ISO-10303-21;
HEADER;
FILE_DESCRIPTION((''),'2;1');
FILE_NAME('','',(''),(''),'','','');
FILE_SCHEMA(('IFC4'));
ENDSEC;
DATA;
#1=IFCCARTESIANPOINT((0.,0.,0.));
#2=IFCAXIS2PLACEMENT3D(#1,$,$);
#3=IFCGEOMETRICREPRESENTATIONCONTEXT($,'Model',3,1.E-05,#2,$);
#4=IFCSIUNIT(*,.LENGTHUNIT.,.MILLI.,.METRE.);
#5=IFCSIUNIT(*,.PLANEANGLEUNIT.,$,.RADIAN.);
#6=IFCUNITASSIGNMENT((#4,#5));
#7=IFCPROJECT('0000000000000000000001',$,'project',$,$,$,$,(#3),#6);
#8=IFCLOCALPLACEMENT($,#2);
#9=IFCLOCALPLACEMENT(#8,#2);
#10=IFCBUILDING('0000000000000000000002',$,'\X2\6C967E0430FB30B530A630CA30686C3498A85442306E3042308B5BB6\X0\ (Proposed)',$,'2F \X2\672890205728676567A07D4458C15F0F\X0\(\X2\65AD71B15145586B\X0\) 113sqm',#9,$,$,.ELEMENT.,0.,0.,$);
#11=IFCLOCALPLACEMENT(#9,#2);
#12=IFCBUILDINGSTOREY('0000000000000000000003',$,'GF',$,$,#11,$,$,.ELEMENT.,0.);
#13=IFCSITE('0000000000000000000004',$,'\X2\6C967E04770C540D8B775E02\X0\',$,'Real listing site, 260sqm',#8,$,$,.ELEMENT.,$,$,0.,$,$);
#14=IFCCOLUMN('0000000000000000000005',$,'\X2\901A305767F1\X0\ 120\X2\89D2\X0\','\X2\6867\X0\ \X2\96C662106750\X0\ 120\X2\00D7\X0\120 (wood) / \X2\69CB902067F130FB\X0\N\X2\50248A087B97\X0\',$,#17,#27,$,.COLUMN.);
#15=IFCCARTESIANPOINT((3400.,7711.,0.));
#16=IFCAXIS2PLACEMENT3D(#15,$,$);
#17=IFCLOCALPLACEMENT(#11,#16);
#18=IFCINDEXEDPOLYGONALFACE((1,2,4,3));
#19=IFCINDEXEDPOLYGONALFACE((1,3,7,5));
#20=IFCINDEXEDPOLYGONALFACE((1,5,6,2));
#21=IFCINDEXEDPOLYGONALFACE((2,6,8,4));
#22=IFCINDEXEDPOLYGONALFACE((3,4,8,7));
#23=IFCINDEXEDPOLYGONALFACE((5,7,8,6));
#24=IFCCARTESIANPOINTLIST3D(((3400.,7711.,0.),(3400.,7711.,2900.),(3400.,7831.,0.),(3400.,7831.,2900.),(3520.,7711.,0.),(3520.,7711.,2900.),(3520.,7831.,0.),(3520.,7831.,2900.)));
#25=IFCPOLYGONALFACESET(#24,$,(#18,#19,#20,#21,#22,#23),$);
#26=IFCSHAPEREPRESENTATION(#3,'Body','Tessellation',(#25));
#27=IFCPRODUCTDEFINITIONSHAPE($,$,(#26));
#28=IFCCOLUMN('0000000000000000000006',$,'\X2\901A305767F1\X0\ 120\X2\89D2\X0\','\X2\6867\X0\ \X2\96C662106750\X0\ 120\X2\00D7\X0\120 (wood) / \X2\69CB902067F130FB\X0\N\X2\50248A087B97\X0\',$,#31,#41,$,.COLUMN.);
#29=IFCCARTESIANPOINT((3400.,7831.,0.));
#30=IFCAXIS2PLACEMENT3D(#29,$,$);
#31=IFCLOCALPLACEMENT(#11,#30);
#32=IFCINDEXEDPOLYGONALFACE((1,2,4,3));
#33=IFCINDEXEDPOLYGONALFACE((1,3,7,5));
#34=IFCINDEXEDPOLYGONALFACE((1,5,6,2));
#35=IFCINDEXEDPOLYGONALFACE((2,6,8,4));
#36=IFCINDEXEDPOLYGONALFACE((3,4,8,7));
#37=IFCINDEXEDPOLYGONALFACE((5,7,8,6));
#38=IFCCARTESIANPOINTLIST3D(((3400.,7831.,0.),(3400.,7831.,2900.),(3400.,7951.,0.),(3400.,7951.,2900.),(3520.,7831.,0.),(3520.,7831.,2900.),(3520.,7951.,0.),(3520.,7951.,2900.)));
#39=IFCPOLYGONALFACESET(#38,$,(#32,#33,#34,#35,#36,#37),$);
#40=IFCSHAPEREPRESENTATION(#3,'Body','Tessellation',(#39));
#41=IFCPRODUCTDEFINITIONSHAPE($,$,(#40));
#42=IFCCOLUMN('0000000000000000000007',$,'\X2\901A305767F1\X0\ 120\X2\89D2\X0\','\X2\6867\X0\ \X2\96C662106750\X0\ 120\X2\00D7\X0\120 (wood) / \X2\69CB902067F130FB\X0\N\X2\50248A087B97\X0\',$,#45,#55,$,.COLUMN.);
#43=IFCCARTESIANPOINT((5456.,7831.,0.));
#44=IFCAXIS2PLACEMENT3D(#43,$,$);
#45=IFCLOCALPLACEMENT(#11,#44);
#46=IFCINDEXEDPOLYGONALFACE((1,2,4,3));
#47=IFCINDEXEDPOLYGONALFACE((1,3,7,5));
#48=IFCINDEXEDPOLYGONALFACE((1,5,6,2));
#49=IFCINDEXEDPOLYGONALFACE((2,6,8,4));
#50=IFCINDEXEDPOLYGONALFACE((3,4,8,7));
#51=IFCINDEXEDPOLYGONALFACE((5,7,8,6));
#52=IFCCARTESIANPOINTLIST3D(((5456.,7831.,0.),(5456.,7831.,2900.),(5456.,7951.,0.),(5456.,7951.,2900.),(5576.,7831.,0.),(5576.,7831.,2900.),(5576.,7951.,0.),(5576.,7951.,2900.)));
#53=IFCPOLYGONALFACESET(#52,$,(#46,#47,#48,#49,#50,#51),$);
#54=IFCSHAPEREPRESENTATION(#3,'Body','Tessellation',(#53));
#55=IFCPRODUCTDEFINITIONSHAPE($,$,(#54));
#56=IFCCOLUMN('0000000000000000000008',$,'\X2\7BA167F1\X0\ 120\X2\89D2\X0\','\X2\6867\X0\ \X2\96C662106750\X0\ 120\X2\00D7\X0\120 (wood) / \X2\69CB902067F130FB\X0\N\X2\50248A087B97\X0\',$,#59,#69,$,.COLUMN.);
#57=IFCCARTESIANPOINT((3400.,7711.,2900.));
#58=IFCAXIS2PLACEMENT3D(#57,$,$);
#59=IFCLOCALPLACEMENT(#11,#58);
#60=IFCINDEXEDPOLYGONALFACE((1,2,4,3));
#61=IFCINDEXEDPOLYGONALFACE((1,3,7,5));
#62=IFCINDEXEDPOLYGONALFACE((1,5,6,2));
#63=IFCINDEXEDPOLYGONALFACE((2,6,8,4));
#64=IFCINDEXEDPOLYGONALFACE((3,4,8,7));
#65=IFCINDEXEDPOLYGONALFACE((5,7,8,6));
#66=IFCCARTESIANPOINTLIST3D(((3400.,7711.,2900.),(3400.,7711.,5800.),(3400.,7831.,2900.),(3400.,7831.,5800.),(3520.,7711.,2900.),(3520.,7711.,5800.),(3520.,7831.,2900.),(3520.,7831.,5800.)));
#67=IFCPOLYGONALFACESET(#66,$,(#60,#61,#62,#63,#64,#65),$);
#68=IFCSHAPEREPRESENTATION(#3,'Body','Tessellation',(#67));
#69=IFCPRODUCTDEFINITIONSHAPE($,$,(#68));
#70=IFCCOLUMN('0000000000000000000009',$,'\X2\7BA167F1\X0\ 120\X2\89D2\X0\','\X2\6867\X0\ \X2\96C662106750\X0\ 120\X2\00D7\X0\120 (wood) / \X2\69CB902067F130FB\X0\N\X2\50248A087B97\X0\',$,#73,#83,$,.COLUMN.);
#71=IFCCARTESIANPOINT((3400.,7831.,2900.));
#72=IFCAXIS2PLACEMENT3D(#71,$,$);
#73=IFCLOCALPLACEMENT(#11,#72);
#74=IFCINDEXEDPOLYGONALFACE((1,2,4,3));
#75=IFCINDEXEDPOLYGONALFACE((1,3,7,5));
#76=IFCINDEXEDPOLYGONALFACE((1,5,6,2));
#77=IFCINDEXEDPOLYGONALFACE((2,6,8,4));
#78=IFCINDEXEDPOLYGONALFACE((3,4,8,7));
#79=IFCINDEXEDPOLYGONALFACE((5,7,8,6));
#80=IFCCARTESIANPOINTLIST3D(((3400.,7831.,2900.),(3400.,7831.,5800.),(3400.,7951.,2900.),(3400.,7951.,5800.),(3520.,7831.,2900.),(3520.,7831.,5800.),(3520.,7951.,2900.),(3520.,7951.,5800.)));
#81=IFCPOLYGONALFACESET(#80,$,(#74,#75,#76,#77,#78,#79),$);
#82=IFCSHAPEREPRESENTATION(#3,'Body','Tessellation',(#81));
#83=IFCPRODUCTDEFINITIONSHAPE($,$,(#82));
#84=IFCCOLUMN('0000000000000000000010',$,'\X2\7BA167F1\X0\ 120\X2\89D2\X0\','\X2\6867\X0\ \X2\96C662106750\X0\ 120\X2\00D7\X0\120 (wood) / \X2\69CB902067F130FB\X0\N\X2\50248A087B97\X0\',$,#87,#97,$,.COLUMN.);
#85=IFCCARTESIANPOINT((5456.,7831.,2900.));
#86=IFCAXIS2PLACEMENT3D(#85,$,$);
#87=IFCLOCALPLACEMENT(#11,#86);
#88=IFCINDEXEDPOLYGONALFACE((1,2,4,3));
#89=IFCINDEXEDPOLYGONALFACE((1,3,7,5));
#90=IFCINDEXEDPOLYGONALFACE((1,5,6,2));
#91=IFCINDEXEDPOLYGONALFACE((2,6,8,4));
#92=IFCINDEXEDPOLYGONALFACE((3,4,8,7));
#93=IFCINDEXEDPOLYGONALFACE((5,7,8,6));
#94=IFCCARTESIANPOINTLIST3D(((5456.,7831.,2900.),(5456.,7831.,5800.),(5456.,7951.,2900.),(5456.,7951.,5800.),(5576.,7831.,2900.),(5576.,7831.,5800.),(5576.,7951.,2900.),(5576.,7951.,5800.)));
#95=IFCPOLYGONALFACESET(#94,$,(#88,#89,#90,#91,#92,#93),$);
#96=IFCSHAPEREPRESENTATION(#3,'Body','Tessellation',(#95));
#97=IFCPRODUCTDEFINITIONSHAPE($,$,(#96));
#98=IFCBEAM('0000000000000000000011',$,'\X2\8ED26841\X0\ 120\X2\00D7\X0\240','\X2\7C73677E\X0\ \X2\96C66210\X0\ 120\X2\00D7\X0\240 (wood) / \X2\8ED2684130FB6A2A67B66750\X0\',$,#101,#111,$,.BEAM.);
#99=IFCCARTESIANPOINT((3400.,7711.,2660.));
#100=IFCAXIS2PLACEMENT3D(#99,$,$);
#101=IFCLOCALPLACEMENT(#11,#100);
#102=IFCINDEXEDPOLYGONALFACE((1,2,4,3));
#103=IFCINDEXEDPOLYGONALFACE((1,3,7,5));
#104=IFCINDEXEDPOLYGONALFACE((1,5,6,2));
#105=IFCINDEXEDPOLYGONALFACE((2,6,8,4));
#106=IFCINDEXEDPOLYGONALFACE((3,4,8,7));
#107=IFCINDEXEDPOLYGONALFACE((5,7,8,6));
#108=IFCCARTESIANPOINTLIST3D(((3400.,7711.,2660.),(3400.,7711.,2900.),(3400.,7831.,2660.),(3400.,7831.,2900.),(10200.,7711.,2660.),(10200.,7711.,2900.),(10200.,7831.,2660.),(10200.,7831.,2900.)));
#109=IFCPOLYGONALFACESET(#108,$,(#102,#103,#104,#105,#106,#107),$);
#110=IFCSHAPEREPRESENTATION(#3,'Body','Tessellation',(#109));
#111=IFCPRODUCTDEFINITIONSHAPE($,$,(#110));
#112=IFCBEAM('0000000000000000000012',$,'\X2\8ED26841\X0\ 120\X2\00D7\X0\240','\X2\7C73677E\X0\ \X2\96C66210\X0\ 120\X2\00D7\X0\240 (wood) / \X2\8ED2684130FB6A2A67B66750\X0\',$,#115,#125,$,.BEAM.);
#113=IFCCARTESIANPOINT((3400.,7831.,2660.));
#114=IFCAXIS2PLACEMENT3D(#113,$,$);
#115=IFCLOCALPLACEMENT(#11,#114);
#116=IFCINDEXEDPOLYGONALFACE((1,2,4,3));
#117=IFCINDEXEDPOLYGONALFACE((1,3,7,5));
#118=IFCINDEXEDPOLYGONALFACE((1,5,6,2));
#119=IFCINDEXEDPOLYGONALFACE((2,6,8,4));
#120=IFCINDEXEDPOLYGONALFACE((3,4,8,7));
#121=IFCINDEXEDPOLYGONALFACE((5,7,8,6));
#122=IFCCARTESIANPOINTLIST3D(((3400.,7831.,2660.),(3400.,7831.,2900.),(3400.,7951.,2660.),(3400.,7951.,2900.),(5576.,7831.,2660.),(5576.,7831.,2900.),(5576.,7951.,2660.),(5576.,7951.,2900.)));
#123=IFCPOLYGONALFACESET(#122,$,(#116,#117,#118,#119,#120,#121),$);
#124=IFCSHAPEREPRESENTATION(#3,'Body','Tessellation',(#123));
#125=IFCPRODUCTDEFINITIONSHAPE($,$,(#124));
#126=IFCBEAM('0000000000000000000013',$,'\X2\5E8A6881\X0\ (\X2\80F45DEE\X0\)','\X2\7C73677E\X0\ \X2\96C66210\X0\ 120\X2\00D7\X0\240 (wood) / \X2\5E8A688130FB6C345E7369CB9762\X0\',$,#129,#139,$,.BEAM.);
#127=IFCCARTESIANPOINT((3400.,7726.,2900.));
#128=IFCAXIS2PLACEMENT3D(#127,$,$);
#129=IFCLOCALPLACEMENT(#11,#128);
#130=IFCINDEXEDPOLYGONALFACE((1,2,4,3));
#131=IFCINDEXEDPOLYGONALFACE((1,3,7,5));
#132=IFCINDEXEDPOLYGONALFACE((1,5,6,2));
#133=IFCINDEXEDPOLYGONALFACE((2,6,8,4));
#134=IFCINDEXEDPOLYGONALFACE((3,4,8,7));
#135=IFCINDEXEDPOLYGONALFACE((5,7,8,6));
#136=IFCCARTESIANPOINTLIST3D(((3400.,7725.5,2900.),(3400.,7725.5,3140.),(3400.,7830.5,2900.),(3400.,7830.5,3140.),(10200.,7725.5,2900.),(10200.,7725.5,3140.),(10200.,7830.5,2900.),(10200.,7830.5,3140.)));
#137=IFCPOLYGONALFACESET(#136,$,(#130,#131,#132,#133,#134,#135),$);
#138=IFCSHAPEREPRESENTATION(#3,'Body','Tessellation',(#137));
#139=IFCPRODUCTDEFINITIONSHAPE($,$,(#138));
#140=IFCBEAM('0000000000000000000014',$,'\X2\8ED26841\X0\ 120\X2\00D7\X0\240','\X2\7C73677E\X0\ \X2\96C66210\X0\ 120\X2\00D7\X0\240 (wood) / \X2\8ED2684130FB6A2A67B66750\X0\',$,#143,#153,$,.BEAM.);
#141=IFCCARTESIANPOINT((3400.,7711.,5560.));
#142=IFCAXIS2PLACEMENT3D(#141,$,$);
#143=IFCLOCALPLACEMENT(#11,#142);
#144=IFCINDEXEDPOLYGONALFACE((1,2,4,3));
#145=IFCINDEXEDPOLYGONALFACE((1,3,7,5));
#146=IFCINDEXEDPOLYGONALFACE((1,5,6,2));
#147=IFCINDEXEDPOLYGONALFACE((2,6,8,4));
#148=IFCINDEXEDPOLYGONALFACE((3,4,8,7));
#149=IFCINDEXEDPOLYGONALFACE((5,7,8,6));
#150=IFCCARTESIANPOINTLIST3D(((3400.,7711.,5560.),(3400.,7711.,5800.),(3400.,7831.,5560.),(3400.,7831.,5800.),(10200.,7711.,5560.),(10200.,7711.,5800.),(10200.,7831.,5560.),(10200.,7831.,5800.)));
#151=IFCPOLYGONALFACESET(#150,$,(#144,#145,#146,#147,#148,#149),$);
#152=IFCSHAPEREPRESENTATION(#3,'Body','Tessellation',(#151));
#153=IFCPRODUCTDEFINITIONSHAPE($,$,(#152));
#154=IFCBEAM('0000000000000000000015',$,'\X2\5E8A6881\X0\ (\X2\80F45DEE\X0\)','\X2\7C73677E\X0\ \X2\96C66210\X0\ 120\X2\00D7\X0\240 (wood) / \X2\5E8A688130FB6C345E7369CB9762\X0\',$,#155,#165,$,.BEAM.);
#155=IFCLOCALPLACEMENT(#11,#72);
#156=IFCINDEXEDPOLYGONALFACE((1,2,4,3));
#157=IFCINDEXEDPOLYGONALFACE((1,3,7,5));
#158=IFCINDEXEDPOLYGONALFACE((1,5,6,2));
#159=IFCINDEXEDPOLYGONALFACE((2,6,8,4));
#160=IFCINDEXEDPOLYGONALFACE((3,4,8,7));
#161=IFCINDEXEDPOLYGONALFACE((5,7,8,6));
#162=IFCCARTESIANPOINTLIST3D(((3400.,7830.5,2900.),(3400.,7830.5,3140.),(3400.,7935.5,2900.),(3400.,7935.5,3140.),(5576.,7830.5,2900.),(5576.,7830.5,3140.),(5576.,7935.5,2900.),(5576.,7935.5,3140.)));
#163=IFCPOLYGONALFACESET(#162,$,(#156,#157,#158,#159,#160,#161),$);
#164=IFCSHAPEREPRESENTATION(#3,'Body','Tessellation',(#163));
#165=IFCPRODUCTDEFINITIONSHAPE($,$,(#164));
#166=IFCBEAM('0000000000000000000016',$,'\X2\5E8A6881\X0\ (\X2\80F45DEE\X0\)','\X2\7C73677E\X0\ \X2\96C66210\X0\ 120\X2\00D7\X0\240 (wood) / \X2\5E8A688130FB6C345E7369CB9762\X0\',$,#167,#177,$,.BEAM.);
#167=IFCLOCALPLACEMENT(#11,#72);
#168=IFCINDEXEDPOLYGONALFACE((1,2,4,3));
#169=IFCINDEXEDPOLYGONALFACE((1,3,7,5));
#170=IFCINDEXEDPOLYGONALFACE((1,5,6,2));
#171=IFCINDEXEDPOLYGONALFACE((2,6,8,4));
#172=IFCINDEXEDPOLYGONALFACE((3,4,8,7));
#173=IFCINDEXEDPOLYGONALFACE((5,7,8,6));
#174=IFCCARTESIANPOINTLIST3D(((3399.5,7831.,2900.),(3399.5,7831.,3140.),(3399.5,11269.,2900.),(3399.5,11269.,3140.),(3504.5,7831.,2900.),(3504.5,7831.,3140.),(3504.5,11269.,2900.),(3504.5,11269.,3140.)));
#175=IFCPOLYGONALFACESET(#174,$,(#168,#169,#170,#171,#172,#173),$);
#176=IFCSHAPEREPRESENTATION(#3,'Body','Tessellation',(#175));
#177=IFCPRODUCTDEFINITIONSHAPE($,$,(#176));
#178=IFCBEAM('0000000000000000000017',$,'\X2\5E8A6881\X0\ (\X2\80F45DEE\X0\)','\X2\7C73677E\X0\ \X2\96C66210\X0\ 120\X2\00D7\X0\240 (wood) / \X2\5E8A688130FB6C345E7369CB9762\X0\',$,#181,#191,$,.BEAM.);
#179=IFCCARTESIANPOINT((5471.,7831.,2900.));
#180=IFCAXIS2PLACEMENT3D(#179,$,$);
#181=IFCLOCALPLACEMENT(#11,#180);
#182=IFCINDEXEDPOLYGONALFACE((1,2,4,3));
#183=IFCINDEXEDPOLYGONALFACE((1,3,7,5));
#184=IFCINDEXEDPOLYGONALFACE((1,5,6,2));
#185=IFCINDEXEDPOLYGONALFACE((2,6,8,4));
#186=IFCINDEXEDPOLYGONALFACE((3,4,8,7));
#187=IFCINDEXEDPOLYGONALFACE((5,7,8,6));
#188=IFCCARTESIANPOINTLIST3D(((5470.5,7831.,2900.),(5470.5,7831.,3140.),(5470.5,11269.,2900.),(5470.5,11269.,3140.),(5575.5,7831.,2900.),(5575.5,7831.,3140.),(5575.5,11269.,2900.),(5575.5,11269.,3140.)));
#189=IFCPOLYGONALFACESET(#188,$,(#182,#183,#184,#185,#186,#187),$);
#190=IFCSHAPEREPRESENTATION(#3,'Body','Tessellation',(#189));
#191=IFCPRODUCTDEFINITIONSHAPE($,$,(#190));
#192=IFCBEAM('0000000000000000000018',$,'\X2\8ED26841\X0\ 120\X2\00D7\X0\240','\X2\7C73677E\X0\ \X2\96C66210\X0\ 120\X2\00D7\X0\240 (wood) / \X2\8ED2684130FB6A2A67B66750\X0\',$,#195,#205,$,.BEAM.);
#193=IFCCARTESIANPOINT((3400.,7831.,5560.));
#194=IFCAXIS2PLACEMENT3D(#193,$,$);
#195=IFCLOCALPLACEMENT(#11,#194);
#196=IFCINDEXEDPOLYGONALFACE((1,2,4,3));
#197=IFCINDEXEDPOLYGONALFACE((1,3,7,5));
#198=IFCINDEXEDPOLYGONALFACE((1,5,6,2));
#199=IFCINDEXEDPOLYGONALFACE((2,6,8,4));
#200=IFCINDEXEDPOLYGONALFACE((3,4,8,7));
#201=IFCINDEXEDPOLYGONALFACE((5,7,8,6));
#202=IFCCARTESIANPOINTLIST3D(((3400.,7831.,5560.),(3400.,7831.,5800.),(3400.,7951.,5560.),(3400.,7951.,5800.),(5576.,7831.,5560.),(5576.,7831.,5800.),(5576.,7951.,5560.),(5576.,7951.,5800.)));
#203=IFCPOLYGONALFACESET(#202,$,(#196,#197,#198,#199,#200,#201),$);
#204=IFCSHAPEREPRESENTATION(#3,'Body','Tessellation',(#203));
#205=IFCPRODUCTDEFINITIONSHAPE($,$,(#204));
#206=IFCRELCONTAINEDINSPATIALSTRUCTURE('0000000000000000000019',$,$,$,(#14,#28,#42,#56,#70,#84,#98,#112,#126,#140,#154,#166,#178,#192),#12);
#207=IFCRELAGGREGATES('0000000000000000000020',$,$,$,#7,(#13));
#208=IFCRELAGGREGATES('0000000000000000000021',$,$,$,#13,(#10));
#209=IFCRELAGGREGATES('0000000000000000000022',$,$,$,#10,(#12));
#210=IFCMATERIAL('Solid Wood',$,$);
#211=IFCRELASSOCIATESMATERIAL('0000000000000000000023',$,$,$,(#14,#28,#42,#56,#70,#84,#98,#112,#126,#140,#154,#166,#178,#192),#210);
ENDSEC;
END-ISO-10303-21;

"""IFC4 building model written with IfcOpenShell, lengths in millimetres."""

from ifc_helpers import new_model, si_unit, frame, frame_2d, origin, place, context, project, spatial, rectangle, extrude, material, element, save


model = new_model("IFC4")

# Units and contexts
model_context = context("Model", 3, precision=1e-05, world=origin())
ifc_project = project(units=[si_unit("LENGTHUNIT", "METRE", prefix="MILLI"), si_unit("PLANEANGLEUNIT", "RADIAN")], contexts=[model_context])

# Site, building, storey
site_placement = place(None, origin())
site = spatial("IfcSite", under=ifc_project, at=site_placement, Name="沖縄県名護市", ObjectType="Real listing site, 260sqm", CompositionType="ELEMENT", RefElevation=0.0)
building_placement = place(site_placement, origin())
building = spatial("IfcBuilding", under=site, at=building_placement, Name="沖縄・サウナと水風呂のある家 (Proposed)", ObjectType="2F 木造在来枠組壁式(断熱充填) 113sqm", CompositionType="ELEMENT", ElevationOfRefHeight=0.0, ElevationOfTerrain=0.0)
storey_placement = place(building_placement, origin())
storey = spatial("IfcBuildingStorey", under=building, at=storey_placement, Name="GF", CompositionType="ELEMENT", Elevation=0.0)

# Columns
ifc_material_1 = material(Name="Solid Wood")
column_1_placement = place(storey_placement, frame((3400.0, 7711.0, 0.0)))
element("IfcColumn", 1, at=column_1_placement, inside=storey, material=ifc_material_1, Name="通し柱 120角", Description="桧 集成材 120×120 (wood) / 構造柱・N値計算", PredefinedType="COLUMN", context=model_context, shape_type="SweptSolid", body=[
    extrude(rectangle(XDim=120.0, YDim=120.0, at=frame_2d((60.0, 60.0))), frame((3400.0, 7711.0, 0.0)), (0.0, 0.0, 1.0), 2900.0),
])
column_2_placement = place(storey_placement, frame((3400.0, 7831.0, 0.0)))
element("IfcColumn", 2, at=column_2_placement, inside=storey, material=ifc_material_1, Name="通し柱 120角", Description="桧 集成材 120×120 (wood) / 構造柱・N値計算", PredefinedType="COLUMN", context=model_context, shape_type="SweptSolid", body=[
    extrude(rectangle(XDim=120.0, YDim=120.0, at=frame_2d((60.0, 60.0))), frame((3400.0, 7831.0, 0.0)), (0.0, 0.0, 1.0), 2900.0),
])
column_3_placement = place(storey_placement, frame((5456.0, 7831.0, 0.0)))
element("IfcColumn", 3, at=column_3_placement, inside=storey, material=ifc_material_1, Name="通し柱 120角", Description="桧 集成材 120×120 (wood) / 構造柱・N値計算", PredefinedType="COLUMN", context=model_context, shape_type="SweptSolid", body=[
    extrude(rectangle(XDim=120.0, YDim=120.0, at=frame_2d((60.0, 60.0))), frame((5456.0, 7831.0, 0.0)), (0.0, 0.0, 1.0), 2900.0),
])
column_4_placement = place(storey_placement, frame((3400.0, 7711.0, 2900.0)))
element("IfcColumn", 4, at=column_4_placement, inside=storey, material=ifc_material_1, Name="管柱 120角", Description="桧 集成材 120×120 (wood) / 構造柱・N値計算", PredefinedType="COLUMN", context=model_context, shape_type="SweptSolid", body=[
    extrude(rectangle(XDim=120.0, YDim=120.0, at=frame_2d((60.0, 60.0))), frame((3400.0, 7711.0, 2900.0)), (0.0, 0.0, 1.0), 2900.0),
])
column_5_placement = place(storey_placement, frame((3400.0, 7831.0, 2900.0)))
element("IfcColumn", 5, at=column_5_placement, inside=storey, material=ifc_material_1, Name="管柱 120角", Description="桧 集成材 120×120 (wood) / 構造柱・N値計算", PredefinedType="COLUMN", context=model_context, shape_type="SweptSolid", body=[
    extrude(rectangle(XDim=120.0, YDim=120.0, at=frame_2d((60.0, 60.0))), frame((3400.0, 7831.0, 2900.0)), (0.0, 0.0, 1.0), 2900.0),
])
column_6_placement = place(storey_placement, frame((5456.0, 7831.0, 2900.0)))
element("IfcColumn", 6, at=column_6_placement, inside=storey, material=ifc_material_1, Name="管柱 120角", Description="桧 集成材 120×120 (wood) / 構造柱・N値計算", PredefinedType="COLUMN", context=model_context, shape_type="SweptSolid", body=[
    extrude(rectangle(XDim=120.0, YDim=120.0, at=frame_2d((60.0, 60.0))), frame((5456.0, 7831.0, 2900.0)), (0.0, 0.0, 1.0), 2900.0),
])

# Beams
beam_1_placement = place(storey_placement, frame((3400.0, 7711.0, 2660.0)))
element("IfcBeam", 7, at=beam_1_placement, inside=storey, material=ifc_material_1, Name="軒桁 120×240", Description="米松 集成 120×240 (wood) / 軒桁・横架材", PredefinedType="BEAM", context=model_context, shape_type="SweptSolid", body=[
    extrude(rectangle(XDim=6800.0, YDim=120.0, at=frame_2d((3400.0, 60.0))), frame((3400.0, 7711.0, 2660.0)), (0.0, 0.0, 1.0), 240.0),
])
beam_2_placement = place(storey_placement, frame((3400.0, 7831.0, 2660.0)))
element("IfcBeam", 8, at=beam_2_placement, inside=storey, material=ifc_material_1, Name="軒桁 120×240", Description="米松 集成 120×240 (wood) / 軒桁・横架材", PredefinedType="BEAM", context=model_context, shape_type="SweptSolid", body=[
    extrude(rectangle(XDim=2176.0, YDim=120.0, at=frame_2d((1088.0, 60.0))), frame((3400.0, 7831.0, 2660.0)), (0.0, 0.0, 1.0), 240.0),
])
beam_3_placement = place(storey_placement, frame((3400.0, 7726.0, 2900.0)))
element("IfcBeam", 9, at=beam_3_placement, inside=storey, material=ifc_material_1, Name="床梁 (胴差)", Description="米松 集成 120×240 (wood) / 床梁・水平構面", PredefinedType="BEAM", context=model_context, shape_type="SweptSolid", body=[
    extrude(rectangle(XDim=6800.0, YDim=105.0, at=frame_2d((3400.0, 52.0))), frame((3400.0, 7726.0, 2900.0)), (0.0, 0.0, 1.0), 240.0),
])
beam_4_placement = place(storey_placement, frame((3400.0, 7711.0, 5560.0)))
element("IfcBeam", 10, at=beam_4_placement, inside=storey, material=ifc_material_1, Name="軒桁 120×240", Description="米松 集成 120×240 (wood) / 軒桁・横架材", PredefinedType="BEAM", context=model_context, shape_type="SweptSolid", body=[
    extrude(rectangle(XDim=6800.0, YDim=120.0, at=frame_2d((3400.0, 60.0))), frame((3400.0, 7711.0, 5560.0)), (0.0, 0.0, 1.0), 240.0),
])
beam_5_placement = place(storey_placement, frame((3400.0, 7831.0, 2900.0)))
element("IfcBeam", 11, at=beam_5_placement, inside=storey, material=ifc_material_1, Name="床梁 (胴差)", Description="米松 集成 120×240 (wood) / 床梁・水平構面", PredefinedType="BEAM", context=model_context, shape_type="SweptSolid", body=[
    extrude(rectangle(XDim=2176.0, YDim=105.0, at=frame_2d((1088.0, 52.0))), frame((3400.0, 7831.0, 2900.0)), (0.0, 0.0, 1.0), 240.0),
])
beam_6_placement = place(storey_placement, frame((3400.0, 7831.0, 2900.0)))
element("IfcBeam", 12, at=beam_6_placement, inside=storey, material=ifc_material_1, Name="床梁 (胴差)", Description="米松 集成 120×240 (wood) / 床梁・水平構面", PredefinedType="BEAM", context=model_context, shape_type="SweptSolid", body=[
    extrude(rectangle(XDim=105.0, YDim=3438.0, at=frame_2d((52.0, 1719.0))), frame((3400.0, 7831.0, 2900.0)), (0.0, 0.0, 1.0), 240.0),
])
beam_7_placement = place(storey_placement, frame((5471.0, 7831.0, 2900.0)))
element("IfcBeam", 13, at=beam_7_placement, inside=storey, material=ifc_material_1, Name="床梁 (胴差)", Description="米松 集成 120×240 (wood) / 床梁・水平構面", PredefinedType="BEAM", context=model_context, shape_type="SweptSolid", body=[
    extrude(rectangle(XDim=105.0, YDim=3438.0, at=frame_2d((52.0, 1719.0))), frame((5471.0, 7831.0, 2900.0)), (0.0, 0.0, 1.0), 240.0),
])
beam_8_placement = place(storey_placement, frame((3400.0, 7831.0, 5560.0)))
element("IfcBeam", 14, at=beam_8_placement, inside=storey, material=ifc_material_1, Name="軒桁 120×240", Description="米松 集成 120×240 (wood) / 軒桁・横架材", PredefinedType="BEAM", context=model_context, shape_type="SweptSolid", body=[
    extrude(rectangle(XDim=2176.0, YDim=120.0, at=frame_2d((1088.0, 60.0))), frame((3400.0, 7831.0, 5560.0)), (0.0, 0.0, 1.0), 240.0),
])

save(model, "model.ifc")
